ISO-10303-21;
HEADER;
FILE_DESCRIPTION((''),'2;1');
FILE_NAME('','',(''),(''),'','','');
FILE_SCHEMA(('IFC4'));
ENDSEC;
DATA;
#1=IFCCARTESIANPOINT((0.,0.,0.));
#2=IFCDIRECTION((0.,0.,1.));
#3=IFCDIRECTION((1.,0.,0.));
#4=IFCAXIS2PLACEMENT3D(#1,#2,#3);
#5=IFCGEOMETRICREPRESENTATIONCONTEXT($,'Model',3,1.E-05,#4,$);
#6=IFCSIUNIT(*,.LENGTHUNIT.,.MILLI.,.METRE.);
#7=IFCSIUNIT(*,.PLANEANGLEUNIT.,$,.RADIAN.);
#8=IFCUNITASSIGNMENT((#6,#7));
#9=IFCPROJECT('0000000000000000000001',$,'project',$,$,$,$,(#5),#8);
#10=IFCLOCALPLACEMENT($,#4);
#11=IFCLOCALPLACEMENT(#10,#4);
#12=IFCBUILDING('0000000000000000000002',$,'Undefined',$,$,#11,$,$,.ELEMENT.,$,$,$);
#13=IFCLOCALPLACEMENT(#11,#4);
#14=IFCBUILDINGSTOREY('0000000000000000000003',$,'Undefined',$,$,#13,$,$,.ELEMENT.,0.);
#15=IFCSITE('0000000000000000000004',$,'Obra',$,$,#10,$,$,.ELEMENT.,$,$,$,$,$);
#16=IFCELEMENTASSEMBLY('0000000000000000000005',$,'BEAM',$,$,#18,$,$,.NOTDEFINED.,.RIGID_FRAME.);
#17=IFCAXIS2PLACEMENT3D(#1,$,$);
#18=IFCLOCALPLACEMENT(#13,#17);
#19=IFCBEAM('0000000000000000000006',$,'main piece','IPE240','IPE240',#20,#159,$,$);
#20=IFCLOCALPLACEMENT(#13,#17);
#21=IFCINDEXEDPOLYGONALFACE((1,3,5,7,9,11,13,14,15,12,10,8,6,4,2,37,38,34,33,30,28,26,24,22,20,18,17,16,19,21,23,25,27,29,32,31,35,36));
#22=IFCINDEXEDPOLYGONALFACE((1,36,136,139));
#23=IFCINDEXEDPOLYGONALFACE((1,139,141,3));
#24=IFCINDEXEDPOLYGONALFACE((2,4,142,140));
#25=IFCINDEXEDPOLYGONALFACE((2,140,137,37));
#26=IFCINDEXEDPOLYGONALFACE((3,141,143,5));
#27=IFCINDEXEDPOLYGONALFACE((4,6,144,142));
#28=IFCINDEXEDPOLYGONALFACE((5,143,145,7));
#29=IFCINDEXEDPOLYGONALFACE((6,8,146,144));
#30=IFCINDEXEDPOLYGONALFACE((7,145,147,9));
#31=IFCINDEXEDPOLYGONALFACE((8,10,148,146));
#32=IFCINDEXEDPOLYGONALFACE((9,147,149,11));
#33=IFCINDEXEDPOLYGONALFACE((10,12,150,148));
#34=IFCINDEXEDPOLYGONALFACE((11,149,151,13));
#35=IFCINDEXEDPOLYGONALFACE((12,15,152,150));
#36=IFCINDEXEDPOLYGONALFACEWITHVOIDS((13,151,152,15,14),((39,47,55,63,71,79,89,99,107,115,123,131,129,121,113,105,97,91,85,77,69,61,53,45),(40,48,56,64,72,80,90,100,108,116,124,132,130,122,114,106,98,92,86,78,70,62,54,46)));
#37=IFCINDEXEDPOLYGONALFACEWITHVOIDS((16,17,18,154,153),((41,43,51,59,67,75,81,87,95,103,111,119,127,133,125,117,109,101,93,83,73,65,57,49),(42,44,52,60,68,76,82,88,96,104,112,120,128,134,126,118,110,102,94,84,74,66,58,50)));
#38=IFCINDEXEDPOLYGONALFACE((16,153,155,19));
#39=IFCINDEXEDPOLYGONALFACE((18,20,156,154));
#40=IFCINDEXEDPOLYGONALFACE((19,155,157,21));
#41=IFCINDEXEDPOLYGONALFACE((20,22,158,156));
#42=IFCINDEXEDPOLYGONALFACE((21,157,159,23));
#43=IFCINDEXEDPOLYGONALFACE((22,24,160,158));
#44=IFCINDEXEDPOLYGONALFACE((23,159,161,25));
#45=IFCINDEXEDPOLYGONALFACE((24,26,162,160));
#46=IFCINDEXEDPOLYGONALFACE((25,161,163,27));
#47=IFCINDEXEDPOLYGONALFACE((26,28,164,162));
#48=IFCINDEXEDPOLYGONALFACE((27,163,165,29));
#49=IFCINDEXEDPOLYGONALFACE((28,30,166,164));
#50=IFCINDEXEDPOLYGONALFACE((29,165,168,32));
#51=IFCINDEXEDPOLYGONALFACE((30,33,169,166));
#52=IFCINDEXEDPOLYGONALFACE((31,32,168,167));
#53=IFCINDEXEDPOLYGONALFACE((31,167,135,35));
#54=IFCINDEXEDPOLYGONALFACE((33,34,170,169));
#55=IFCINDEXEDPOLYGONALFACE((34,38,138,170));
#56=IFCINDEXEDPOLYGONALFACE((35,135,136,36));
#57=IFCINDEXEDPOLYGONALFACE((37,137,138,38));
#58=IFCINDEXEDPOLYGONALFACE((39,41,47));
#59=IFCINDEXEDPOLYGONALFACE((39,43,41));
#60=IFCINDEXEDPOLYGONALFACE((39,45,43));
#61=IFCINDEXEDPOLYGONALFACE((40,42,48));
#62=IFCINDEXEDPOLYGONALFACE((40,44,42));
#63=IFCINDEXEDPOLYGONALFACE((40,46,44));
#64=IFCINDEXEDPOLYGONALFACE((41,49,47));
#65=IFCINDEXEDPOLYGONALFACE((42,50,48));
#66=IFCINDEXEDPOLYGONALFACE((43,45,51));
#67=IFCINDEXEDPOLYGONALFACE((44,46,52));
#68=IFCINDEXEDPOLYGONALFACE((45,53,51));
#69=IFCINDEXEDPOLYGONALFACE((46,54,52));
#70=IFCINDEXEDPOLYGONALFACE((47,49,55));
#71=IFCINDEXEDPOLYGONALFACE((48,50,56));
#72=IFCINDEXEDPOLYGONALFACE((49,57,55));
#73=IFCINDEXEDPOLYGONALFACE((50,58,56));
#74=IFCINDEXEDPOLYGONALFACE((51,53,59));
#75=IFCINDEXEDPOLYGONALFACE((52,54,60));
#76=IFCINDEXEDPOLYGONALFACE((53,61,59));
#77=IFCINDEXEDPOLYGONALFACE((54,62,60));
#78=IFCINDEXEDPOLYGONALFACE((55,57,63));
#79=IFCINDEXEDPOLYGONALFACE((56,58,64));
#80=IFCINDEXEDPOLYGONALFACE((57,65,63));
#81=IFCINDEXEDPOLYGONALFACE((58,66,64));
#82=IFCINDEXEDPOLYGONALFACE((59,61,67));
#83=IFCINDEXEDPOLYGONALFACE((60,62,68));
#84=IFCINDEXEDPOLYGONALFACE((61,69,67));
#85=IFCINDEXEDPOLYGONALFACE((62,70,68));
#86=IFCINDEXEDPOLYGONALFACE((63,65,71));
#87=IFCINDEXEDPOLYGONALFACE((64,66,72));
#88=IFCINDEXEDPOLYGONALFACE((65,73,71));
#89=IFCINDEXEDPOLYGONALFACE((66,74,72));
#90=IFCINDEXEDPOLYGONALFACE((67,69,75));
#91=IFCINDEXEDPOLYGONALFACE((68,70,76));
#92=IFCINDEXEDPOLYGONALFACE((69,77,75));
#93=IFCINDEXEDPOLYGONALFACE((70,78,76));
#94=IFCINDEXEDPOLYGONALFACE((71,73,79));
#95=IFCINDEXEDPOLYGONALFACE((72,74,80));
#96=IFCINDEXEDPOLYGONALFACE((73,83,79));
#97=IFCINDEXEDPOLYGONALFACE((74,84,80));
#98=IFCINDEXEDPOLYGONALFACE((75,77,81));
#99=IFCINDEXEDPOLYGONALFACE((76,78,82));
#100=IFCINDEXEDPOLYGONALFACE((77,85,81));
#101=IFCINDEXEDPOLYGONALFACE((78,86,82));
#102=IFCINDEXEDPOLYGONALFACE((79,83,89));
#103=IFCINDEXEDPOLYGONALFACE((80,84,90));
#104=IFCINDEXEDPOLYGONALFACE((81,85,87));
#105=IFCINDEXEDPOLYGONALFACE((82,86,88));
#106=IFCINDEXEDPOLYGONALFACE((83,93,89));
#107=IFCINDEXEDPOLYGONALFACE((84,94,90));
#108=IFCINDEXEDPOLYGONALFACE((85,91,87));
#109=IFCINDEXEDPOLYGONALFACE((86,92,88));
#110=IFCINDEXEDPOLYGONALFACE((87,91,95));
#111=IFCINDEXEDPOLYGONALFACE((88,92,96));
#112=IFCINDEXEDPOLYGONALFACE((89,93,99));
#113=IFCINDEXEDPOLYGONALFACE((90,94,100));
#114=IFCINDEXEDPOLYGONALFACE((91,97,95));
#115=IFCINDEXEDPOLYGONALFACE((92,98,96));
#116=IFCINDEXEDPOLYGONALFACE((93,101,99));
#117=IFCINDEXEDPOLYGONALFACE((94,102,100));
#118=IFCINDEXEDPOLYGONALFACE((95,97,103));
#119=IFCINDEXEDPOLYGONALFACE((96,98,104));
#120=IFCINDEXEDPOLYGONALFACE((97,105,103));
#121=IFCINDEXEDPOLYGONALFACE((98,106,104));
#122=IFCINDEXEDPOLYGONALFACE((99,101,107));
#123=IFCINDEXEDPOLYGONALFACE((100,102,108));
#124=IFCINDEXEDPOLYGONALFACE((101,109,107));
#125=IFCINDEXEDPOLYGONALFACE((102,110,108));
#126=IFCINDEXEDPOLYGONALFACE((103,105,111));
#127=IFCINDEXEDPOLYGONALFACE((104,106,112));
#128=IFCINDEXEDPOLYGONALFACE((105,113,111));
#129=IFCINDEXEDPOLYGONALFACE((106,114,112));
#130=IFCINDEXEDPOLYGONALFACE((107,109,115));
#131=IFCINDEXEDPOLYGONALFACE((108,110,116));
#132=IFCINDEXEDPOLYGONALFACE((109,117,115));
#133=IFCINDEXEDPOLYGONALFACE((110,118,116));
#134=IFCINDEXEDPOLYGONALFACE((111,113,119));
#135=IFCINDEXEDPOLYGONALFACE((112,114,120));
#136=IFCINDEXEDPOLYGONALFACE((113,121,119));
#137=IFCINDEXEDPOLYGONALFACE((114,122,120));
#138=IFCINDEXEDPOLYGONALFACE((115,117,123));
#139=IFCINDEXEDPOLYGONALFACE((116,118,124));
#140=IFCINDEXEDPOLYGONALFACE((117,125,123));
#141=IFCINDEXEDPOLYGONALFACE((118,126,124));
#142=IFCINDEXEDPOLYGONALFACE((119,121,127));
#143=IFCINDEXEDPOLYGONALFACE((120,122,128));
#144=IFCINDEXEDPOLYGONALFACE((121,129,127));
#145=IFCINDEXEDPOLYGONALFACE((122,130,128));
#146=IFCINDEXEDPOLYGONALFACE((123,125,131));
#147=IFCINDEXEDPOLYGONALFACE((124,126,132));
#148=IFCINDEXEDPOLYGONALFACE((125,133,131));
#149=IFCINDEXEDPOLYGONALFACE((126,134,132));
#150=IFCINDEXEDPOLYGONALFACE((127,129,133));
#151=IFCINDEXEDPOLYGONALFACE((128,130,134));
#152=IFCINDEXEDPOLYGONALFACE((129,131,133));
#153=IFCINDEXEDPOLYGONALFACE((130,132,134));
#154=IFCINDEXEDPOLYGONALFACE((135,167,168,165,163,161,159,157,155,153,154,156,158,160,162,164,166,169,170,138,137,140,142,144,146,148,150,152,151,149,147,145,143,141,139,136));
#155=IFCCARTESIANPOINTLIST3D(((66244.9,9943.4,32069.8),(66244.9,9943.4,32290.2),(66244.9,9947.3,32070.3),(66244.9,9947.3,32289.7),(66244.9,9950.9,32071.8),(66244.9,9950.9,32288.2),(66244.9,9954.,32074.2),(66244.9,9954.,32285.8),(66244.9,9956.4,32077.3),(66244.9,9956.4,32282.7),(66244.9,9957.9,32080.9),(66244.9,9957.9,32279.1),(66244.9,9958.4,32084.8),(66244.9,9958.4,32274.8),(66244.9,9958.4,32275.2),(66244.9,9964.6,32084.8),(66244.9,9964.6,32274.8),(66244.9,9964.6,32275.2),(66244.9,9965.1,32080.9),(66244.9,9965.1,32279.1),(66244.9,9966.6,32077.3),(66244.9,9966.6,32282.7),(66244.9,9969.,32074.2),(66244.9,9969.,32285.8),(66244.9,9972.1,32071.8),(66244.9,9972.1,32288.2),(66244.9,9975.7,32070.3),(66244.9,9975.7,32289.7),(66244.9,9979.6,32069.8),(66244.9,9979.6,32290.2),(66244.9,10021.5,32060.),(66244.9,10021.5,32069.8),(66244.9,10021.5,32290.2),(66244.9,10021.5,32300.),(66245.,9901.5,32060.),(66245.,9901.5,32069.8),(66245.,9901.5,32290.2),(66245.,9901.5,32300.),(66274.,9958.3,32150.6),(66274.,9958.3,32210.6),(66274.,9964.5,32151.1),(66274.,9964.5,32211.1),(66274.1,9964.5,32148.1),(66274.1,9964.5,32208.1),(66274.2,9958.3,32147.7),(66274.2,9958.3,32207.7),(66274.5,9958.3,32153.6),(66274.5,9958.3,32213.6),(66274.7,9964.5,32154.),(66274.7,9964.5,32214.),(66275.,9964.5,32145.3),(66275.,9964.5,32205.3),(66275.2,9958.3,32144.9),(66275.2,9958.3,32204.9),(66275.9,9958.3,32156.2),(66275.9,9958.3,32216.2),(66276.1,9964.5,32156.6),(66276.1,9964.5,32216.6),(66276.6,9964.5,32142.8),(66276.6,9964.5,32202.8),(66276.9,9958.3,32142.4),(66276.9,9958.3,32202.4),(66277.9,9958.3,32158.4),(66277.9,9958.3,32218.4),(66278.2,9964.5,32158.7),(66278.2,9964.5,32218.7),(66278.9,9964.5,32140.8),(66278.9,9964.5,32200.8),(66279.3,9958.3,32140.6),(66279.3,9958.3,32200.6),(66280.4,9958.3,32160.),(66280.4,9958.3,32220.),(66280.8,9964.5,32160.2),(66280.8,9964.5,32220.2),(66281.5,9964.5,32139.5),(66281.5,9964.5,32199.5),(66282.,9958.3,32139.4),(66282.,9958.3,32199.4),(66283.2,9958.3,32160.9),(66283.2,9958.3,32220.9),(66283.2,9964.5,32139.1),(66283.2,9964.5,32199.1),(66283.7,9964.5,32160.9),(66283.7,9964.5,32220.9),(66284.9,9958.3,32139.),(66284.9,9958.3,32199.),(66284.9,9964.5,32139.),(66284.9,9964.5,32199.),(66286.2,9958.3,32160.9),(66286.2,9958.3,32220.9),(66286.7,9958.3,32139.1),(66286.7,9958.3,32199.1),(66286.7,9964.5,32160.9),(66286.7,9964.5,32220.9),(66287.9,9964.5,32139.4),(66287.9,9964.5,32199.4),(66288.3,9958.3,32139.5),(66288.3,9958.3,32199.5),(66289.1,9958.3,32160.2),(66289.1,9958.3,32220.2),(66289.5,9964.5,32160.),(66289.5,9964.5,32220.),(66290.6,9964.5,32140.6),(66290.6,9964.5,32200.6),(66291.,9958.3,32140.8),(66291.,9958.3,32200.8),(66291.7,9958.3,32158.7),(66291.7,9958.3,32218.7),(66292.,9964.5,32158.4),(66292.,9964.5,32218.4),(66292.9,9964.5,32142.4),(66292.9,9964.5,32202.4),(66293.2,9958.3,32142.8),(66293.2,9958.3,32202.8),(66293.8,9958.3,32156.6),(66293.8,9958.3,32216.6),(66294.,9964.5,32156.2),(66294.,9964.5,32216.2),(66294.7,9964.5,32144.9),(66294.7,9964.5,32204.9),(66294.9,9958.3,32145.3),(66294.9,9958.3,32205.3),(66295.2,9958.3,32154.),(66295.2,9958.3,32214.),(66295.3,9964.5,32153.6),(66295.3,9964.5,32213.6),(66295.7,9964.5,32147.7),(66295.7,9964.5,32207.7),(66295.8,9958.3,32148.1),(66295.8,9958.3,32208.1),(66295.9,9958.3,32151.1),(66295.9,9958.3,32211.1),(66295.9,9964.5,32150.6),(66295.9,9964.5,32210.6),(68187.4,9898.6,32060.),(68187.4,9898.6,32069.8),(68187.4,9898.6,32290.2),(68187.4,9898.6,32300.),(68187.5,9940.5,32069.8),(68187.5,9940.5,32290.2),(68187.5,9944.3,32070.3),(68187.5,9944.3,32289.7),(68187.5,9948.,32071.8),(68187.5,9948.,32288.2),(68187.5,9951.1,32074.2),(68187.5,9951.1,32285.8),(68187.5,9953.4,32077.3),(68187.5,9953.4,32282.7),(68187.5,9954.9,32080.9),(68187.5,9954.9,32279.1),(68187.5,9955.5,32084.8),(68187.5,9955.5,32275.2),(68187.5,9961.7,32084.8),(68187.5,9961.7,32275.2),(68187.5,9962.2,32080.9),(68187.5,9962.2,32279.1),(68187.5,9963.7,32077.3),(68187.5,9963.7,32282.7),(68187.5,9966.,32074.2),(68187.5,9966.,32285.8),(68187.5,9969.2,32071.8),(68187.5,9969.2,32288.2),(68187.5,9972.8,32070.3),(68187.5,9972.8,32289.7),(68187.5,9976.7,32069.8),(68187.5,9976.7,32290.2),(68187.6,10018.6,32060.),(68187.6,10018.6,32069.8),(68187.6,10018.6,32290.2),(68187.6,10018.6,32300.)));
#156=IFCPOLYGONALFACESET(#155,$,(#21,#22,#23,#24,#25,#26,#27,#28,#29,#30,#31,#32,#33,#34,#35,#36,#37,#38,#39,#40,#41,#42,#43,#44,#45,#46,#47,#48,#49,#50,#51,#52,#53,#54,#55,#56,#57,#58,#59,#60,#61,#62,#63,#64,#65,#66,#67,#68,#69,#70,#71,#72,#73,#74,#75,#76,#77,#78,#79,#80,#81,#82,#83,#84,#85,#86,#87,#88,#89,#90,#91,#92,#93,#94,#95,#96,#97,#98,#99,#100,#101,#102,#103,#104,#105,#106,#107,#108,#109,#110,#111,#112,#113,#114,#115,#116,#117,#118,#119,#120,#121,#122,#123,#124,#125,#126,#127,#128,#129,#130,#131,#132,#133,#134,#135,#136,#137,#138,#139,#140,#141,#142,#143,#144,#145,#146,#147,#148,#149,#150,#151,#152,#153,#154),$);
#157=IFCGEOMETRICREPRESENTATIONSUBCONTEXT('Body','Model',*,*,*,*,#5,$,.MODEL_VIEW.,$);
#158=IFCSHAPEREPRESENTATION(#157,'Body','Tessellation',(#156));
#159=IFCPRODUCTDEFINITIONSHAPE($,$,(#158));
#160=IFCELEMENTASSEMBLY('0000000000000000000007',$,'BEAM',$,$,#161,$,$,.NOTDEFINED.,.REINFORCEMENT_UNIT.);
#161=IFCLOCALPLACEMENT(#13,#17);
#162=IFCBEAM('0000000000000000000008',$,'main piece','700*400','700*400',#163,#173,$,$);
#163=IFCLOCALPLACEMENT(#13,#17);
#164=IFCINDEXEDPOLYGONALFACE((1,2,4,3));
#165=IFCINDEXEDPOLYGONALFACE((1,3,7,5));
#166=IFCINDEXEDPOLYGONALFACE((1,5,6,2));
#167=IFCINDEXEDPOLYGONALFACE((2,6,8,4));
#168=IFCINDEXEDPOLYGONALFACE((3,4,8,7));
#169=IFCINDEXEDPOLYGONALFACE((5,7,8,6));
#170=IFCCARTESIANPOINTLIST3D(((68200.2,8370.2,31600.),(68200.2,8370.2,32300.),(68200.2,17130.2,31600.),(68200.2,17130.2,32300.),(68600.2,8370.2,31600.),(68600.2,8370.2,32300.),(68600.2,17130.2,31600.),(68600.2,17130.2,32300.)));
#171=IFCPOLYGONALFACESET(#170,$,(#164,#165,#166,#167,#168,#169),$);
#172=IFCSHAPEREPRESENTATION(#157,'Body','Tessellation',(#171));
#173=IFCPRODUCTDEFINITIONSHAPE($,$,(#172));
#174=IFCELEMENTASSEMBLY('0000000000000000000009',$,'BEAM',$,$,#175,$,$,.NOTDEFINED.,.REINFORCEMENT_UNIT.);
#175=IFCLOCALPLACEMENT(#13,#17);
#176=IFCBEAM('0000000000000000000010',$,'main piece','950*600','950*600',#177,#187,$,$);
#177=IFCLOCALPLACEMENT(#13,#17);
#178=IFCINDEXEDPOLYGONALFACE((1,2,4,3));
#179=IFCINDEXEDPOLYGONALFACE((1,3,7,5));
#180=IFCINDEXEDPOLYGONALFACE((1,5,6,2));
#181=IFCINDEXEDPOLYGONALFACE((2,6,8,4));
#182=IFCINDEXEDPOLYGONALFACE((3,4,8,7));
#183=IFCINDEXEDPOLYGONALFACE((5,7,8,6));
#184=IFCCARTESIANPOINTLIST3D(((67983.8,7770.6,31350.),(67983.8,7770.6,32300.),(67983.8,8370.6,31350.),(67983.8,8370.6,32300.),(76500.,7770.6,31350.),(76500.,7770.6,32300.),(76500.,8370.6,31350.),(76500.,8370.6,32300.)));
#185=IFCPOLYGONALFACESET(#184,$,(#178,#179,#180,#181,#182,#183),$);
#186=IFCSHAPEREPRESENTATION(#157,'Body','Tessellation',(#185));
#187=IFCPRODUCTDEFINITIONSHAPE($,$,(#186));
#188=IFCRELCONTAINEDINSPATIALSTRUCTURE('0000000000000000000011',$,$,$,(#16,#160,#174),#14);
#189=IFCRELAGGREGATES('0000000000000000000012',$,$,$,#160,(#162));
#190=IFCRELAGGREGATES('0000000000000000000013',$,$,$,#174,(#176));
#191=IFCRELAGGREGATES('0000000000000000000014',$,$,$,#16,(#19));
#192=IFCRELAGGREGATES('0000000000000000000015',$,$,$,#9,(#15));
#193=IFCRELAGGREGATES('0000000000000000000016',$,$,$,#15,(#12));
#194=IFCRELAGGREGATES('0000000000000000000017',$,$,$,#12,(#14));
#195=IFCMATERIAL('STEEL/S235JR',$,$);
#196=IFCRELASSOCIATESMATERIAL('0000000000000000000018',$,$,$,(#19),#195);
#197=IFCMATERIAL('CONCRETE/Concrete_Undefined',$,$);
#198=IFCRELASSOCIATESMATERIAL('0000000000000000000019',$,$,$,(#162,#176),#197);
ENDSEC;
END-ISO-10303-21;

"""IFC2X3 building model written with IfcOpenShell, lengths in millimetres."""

from ifc_helpers import new_model, si_unit, frame, origin_with_axes, origin_2d_with_axis, place, context, subcontext, project, spatial, rectangle, circle, i_section, extrude, clip, halfspace, source, transform, mapped, material, element, aggregate, save


model = new_model("IFC2X3")

# Units and contexts
model_context = context("Model", 3, precision=1e-05, world=origin_with_axes())
body_context = subcontext(model_context, "Body", "Model", "MODEL_VIEW")
ifc_project = project(units=[si_unit("LENGTHUNIT", "METRE", prefix="MILLI"), si_unit("PLANEANGLEUNIT", "RADIAN")], contexts=[model_context])

# Site, building, storey
site_placement = place(None, origin_with_axes())
site = spatial("IfcSite", under=ifc_project, at=site_placement, Name="Obra", CompositionType="ELEMENT")
building_placement = place(site_placement, origin_with_axes())
building = spatial("IfcBuilding", under=site, at=building_placement, Name="Undefined", CompositionType="ELEMENT")
storey_placement = place(building_placement, origin_with_axes())
storey = spatial("IfcBuildingStorey", under=building, at=storey_placement, Name="Undefined", CompositionType="ELEMENT", Elevation=0.0)

# Element assembly, beam, openings
assembly_1_placement = place(storey_placement, origin_with_axes())
assembly_1 = element("IfcElementAssembly", 1, at=assembly_1_placement, inside=storey, Name="BEAM", AssemblyPlace="NOTDEFINED", PredefinedType="RIGID_FRAME")
ifc_material_1 = material(Name="STEEL/S235JR")
beam_1_placement = place(assembly_1_placement, frame((66135.0, 9961.6, 32180.0), z_axis=(0.0, 0.0, 1.0), x_axis=(0.999999, -0.001509, 0.0)))
beam_1 = element("IfcBeam", 2, at=beam_1_placement, material=ifc_material_1, Name="main piece", Description="IPE240", ObjectType="IPE240", context=body_context, shape_type="Clipping", body=[
    clip(extrude(i_section(OverallWidth=120.0, OverallDepth=240.0, WebThickness=6.2, FlangeThickness=9.8, FilletRadius=15.0, at=origin_2d_with_axis()), frame((2052.5, 0.0, 0.0), z_axis=(-1.0, 0.0, 0.0), x_axis=(0.0, -1.0, 0.0)), (0.0, 0.0, 1.0), 1942.9), halfspace(frame((109.9, 0.2, -220.0), z_axis=(0.999998, 0.002097, 0.0), x_axis=(0.002097, -0.999998, 0.0)), True)),
])
opening_1_placement = place(assembly_1_placement, frame((66135.0, 9961.6, 32180.0), z_axis=(0.0, 0.0, 1.0), x_axis=(0.999999, -0.001509, 0.0)))
element("IfcOpeningElement", 3, at=opening_1_placement, cuts=beam_1, ObjectType="Recess", context=body_context, shape_type="SweptSolid", body=[
    extrude(rectangle(XDim=26.2, YDim=76.2, at=origin_2d_with_axis()), frame((72.0, -65.2, 107.9), z_axis=(-0.002097, 0.999998, 0.0), x_axis=(0.0, 0.0, -1.0)), (0.0, 0.0, 1.0), 126.1),
])
shared_shape_1 = source(origin_with_axes(), body_context, "Body", "SweptSolid", [
    extrude(circle(Radius=11.0, at=origin_2d_with_axis()), frame((0.0, -3.4, 0.0), z_axis=(0.0, 1.0, 0.0), x_axis=(1.0, 0.0, 0.0)), (0.0, 0.0, 1.0), 6.4),
])
opening_2_placement = place(assembly_1_placement, frame((66244.9, 9961.6, 32250.0), z_axis=(1.0, 0.000588, 0.0), x_axis=(0.0, 0.0, -1.0)))
element("IfcOpeningElement", 4, at=opening_2_placement, cuts=beam_1, ObjectType="Opening", context=body_context, shape_type="MappedRepresentation", body=[
    mapped(shared_shape_1, transform((40.0, 0.0, 40.0))),
    mapped(shared_shape_1, transform((100.0, 0.0, 40.0))),
])

# Element assemblies, beams
assembly_2_placement = place(storey_placement, origin_with_axes())
assembly_2 = element("IfcElementAssembly", 5, at=assembly_2_placement, inside=storey, Name="BEAM", AssemblyPlace="NOTDEFINED", PredefinedType="REINFORCEMENT_UNIT")
ifc_material_2 = material(Name="CONCRETE/Concrete_Undefined")
beam_2_placement = place(assembly_2_placement, frame((68400.2, 8370.2, 31950.0), z_axis=(0.0, 0.0, 1.0), x_axis=(0.0, 1.0, 0.0)))
beam_2 = element("IfcBeam", 6, at=beam_2_placement, material=ifc_material_2, Name="main piece", Description="700*400", ObjectType="700*400", context=body_context, shape_type="SweptSolid", body=[
    extrude(rectangle(XDim=400.0, YDim=700.0, at=origin_2d_with_axis()), frame((8760.0, 0.0, 0.0), z_axis=(-1.0, 0.0, 0.0), x_axis=(0.0, -1.0, 0.0)), (0.0, 0.0, 1.0), 8760.0),
])
aggregate(assembly_2, [beam_2])
assembly_3_placement = place(storey_placement, origin_with_axes())
assembly_3 = element("IfcElementAssembly", 7, at=assembly_3_placement, inside=storey, Name="BEAM", AssemblyPlace="NOTDEFINED", PredefinedType="REINFORCEMENT_UNIT")
beam_3_placement = place(assembly_3_placement, frame((67983.8, 8070.6, 31825.0), z_axis=(0.0, 0.0, 1.0), x_axis=(1.0, 0.0, 0.0)))
beam_3 = element("IfcBeam", 8, at=beam_3_placement, material=ifc_material_2, Name="main piece", Description="950*600", ObjectType="950*600", context=body_context, shape_type="SweptSolid", body=[
    extrude(rectangle(XDim=600.0, YDim=950.0, at=origin_2d_with_axis()), frame((8516.2, 0.0, 0.0), z_axis=(-1.0, 0.0, 0.0), x_axis=(0.0, -1.0, 0.0)), (0.0, 0.0, 1.0), 8516.2),
])
aggregate(assembly_3, [beam_3])

aggregate(assembly_1, [beam_1])

save(model, "model.ifc")
